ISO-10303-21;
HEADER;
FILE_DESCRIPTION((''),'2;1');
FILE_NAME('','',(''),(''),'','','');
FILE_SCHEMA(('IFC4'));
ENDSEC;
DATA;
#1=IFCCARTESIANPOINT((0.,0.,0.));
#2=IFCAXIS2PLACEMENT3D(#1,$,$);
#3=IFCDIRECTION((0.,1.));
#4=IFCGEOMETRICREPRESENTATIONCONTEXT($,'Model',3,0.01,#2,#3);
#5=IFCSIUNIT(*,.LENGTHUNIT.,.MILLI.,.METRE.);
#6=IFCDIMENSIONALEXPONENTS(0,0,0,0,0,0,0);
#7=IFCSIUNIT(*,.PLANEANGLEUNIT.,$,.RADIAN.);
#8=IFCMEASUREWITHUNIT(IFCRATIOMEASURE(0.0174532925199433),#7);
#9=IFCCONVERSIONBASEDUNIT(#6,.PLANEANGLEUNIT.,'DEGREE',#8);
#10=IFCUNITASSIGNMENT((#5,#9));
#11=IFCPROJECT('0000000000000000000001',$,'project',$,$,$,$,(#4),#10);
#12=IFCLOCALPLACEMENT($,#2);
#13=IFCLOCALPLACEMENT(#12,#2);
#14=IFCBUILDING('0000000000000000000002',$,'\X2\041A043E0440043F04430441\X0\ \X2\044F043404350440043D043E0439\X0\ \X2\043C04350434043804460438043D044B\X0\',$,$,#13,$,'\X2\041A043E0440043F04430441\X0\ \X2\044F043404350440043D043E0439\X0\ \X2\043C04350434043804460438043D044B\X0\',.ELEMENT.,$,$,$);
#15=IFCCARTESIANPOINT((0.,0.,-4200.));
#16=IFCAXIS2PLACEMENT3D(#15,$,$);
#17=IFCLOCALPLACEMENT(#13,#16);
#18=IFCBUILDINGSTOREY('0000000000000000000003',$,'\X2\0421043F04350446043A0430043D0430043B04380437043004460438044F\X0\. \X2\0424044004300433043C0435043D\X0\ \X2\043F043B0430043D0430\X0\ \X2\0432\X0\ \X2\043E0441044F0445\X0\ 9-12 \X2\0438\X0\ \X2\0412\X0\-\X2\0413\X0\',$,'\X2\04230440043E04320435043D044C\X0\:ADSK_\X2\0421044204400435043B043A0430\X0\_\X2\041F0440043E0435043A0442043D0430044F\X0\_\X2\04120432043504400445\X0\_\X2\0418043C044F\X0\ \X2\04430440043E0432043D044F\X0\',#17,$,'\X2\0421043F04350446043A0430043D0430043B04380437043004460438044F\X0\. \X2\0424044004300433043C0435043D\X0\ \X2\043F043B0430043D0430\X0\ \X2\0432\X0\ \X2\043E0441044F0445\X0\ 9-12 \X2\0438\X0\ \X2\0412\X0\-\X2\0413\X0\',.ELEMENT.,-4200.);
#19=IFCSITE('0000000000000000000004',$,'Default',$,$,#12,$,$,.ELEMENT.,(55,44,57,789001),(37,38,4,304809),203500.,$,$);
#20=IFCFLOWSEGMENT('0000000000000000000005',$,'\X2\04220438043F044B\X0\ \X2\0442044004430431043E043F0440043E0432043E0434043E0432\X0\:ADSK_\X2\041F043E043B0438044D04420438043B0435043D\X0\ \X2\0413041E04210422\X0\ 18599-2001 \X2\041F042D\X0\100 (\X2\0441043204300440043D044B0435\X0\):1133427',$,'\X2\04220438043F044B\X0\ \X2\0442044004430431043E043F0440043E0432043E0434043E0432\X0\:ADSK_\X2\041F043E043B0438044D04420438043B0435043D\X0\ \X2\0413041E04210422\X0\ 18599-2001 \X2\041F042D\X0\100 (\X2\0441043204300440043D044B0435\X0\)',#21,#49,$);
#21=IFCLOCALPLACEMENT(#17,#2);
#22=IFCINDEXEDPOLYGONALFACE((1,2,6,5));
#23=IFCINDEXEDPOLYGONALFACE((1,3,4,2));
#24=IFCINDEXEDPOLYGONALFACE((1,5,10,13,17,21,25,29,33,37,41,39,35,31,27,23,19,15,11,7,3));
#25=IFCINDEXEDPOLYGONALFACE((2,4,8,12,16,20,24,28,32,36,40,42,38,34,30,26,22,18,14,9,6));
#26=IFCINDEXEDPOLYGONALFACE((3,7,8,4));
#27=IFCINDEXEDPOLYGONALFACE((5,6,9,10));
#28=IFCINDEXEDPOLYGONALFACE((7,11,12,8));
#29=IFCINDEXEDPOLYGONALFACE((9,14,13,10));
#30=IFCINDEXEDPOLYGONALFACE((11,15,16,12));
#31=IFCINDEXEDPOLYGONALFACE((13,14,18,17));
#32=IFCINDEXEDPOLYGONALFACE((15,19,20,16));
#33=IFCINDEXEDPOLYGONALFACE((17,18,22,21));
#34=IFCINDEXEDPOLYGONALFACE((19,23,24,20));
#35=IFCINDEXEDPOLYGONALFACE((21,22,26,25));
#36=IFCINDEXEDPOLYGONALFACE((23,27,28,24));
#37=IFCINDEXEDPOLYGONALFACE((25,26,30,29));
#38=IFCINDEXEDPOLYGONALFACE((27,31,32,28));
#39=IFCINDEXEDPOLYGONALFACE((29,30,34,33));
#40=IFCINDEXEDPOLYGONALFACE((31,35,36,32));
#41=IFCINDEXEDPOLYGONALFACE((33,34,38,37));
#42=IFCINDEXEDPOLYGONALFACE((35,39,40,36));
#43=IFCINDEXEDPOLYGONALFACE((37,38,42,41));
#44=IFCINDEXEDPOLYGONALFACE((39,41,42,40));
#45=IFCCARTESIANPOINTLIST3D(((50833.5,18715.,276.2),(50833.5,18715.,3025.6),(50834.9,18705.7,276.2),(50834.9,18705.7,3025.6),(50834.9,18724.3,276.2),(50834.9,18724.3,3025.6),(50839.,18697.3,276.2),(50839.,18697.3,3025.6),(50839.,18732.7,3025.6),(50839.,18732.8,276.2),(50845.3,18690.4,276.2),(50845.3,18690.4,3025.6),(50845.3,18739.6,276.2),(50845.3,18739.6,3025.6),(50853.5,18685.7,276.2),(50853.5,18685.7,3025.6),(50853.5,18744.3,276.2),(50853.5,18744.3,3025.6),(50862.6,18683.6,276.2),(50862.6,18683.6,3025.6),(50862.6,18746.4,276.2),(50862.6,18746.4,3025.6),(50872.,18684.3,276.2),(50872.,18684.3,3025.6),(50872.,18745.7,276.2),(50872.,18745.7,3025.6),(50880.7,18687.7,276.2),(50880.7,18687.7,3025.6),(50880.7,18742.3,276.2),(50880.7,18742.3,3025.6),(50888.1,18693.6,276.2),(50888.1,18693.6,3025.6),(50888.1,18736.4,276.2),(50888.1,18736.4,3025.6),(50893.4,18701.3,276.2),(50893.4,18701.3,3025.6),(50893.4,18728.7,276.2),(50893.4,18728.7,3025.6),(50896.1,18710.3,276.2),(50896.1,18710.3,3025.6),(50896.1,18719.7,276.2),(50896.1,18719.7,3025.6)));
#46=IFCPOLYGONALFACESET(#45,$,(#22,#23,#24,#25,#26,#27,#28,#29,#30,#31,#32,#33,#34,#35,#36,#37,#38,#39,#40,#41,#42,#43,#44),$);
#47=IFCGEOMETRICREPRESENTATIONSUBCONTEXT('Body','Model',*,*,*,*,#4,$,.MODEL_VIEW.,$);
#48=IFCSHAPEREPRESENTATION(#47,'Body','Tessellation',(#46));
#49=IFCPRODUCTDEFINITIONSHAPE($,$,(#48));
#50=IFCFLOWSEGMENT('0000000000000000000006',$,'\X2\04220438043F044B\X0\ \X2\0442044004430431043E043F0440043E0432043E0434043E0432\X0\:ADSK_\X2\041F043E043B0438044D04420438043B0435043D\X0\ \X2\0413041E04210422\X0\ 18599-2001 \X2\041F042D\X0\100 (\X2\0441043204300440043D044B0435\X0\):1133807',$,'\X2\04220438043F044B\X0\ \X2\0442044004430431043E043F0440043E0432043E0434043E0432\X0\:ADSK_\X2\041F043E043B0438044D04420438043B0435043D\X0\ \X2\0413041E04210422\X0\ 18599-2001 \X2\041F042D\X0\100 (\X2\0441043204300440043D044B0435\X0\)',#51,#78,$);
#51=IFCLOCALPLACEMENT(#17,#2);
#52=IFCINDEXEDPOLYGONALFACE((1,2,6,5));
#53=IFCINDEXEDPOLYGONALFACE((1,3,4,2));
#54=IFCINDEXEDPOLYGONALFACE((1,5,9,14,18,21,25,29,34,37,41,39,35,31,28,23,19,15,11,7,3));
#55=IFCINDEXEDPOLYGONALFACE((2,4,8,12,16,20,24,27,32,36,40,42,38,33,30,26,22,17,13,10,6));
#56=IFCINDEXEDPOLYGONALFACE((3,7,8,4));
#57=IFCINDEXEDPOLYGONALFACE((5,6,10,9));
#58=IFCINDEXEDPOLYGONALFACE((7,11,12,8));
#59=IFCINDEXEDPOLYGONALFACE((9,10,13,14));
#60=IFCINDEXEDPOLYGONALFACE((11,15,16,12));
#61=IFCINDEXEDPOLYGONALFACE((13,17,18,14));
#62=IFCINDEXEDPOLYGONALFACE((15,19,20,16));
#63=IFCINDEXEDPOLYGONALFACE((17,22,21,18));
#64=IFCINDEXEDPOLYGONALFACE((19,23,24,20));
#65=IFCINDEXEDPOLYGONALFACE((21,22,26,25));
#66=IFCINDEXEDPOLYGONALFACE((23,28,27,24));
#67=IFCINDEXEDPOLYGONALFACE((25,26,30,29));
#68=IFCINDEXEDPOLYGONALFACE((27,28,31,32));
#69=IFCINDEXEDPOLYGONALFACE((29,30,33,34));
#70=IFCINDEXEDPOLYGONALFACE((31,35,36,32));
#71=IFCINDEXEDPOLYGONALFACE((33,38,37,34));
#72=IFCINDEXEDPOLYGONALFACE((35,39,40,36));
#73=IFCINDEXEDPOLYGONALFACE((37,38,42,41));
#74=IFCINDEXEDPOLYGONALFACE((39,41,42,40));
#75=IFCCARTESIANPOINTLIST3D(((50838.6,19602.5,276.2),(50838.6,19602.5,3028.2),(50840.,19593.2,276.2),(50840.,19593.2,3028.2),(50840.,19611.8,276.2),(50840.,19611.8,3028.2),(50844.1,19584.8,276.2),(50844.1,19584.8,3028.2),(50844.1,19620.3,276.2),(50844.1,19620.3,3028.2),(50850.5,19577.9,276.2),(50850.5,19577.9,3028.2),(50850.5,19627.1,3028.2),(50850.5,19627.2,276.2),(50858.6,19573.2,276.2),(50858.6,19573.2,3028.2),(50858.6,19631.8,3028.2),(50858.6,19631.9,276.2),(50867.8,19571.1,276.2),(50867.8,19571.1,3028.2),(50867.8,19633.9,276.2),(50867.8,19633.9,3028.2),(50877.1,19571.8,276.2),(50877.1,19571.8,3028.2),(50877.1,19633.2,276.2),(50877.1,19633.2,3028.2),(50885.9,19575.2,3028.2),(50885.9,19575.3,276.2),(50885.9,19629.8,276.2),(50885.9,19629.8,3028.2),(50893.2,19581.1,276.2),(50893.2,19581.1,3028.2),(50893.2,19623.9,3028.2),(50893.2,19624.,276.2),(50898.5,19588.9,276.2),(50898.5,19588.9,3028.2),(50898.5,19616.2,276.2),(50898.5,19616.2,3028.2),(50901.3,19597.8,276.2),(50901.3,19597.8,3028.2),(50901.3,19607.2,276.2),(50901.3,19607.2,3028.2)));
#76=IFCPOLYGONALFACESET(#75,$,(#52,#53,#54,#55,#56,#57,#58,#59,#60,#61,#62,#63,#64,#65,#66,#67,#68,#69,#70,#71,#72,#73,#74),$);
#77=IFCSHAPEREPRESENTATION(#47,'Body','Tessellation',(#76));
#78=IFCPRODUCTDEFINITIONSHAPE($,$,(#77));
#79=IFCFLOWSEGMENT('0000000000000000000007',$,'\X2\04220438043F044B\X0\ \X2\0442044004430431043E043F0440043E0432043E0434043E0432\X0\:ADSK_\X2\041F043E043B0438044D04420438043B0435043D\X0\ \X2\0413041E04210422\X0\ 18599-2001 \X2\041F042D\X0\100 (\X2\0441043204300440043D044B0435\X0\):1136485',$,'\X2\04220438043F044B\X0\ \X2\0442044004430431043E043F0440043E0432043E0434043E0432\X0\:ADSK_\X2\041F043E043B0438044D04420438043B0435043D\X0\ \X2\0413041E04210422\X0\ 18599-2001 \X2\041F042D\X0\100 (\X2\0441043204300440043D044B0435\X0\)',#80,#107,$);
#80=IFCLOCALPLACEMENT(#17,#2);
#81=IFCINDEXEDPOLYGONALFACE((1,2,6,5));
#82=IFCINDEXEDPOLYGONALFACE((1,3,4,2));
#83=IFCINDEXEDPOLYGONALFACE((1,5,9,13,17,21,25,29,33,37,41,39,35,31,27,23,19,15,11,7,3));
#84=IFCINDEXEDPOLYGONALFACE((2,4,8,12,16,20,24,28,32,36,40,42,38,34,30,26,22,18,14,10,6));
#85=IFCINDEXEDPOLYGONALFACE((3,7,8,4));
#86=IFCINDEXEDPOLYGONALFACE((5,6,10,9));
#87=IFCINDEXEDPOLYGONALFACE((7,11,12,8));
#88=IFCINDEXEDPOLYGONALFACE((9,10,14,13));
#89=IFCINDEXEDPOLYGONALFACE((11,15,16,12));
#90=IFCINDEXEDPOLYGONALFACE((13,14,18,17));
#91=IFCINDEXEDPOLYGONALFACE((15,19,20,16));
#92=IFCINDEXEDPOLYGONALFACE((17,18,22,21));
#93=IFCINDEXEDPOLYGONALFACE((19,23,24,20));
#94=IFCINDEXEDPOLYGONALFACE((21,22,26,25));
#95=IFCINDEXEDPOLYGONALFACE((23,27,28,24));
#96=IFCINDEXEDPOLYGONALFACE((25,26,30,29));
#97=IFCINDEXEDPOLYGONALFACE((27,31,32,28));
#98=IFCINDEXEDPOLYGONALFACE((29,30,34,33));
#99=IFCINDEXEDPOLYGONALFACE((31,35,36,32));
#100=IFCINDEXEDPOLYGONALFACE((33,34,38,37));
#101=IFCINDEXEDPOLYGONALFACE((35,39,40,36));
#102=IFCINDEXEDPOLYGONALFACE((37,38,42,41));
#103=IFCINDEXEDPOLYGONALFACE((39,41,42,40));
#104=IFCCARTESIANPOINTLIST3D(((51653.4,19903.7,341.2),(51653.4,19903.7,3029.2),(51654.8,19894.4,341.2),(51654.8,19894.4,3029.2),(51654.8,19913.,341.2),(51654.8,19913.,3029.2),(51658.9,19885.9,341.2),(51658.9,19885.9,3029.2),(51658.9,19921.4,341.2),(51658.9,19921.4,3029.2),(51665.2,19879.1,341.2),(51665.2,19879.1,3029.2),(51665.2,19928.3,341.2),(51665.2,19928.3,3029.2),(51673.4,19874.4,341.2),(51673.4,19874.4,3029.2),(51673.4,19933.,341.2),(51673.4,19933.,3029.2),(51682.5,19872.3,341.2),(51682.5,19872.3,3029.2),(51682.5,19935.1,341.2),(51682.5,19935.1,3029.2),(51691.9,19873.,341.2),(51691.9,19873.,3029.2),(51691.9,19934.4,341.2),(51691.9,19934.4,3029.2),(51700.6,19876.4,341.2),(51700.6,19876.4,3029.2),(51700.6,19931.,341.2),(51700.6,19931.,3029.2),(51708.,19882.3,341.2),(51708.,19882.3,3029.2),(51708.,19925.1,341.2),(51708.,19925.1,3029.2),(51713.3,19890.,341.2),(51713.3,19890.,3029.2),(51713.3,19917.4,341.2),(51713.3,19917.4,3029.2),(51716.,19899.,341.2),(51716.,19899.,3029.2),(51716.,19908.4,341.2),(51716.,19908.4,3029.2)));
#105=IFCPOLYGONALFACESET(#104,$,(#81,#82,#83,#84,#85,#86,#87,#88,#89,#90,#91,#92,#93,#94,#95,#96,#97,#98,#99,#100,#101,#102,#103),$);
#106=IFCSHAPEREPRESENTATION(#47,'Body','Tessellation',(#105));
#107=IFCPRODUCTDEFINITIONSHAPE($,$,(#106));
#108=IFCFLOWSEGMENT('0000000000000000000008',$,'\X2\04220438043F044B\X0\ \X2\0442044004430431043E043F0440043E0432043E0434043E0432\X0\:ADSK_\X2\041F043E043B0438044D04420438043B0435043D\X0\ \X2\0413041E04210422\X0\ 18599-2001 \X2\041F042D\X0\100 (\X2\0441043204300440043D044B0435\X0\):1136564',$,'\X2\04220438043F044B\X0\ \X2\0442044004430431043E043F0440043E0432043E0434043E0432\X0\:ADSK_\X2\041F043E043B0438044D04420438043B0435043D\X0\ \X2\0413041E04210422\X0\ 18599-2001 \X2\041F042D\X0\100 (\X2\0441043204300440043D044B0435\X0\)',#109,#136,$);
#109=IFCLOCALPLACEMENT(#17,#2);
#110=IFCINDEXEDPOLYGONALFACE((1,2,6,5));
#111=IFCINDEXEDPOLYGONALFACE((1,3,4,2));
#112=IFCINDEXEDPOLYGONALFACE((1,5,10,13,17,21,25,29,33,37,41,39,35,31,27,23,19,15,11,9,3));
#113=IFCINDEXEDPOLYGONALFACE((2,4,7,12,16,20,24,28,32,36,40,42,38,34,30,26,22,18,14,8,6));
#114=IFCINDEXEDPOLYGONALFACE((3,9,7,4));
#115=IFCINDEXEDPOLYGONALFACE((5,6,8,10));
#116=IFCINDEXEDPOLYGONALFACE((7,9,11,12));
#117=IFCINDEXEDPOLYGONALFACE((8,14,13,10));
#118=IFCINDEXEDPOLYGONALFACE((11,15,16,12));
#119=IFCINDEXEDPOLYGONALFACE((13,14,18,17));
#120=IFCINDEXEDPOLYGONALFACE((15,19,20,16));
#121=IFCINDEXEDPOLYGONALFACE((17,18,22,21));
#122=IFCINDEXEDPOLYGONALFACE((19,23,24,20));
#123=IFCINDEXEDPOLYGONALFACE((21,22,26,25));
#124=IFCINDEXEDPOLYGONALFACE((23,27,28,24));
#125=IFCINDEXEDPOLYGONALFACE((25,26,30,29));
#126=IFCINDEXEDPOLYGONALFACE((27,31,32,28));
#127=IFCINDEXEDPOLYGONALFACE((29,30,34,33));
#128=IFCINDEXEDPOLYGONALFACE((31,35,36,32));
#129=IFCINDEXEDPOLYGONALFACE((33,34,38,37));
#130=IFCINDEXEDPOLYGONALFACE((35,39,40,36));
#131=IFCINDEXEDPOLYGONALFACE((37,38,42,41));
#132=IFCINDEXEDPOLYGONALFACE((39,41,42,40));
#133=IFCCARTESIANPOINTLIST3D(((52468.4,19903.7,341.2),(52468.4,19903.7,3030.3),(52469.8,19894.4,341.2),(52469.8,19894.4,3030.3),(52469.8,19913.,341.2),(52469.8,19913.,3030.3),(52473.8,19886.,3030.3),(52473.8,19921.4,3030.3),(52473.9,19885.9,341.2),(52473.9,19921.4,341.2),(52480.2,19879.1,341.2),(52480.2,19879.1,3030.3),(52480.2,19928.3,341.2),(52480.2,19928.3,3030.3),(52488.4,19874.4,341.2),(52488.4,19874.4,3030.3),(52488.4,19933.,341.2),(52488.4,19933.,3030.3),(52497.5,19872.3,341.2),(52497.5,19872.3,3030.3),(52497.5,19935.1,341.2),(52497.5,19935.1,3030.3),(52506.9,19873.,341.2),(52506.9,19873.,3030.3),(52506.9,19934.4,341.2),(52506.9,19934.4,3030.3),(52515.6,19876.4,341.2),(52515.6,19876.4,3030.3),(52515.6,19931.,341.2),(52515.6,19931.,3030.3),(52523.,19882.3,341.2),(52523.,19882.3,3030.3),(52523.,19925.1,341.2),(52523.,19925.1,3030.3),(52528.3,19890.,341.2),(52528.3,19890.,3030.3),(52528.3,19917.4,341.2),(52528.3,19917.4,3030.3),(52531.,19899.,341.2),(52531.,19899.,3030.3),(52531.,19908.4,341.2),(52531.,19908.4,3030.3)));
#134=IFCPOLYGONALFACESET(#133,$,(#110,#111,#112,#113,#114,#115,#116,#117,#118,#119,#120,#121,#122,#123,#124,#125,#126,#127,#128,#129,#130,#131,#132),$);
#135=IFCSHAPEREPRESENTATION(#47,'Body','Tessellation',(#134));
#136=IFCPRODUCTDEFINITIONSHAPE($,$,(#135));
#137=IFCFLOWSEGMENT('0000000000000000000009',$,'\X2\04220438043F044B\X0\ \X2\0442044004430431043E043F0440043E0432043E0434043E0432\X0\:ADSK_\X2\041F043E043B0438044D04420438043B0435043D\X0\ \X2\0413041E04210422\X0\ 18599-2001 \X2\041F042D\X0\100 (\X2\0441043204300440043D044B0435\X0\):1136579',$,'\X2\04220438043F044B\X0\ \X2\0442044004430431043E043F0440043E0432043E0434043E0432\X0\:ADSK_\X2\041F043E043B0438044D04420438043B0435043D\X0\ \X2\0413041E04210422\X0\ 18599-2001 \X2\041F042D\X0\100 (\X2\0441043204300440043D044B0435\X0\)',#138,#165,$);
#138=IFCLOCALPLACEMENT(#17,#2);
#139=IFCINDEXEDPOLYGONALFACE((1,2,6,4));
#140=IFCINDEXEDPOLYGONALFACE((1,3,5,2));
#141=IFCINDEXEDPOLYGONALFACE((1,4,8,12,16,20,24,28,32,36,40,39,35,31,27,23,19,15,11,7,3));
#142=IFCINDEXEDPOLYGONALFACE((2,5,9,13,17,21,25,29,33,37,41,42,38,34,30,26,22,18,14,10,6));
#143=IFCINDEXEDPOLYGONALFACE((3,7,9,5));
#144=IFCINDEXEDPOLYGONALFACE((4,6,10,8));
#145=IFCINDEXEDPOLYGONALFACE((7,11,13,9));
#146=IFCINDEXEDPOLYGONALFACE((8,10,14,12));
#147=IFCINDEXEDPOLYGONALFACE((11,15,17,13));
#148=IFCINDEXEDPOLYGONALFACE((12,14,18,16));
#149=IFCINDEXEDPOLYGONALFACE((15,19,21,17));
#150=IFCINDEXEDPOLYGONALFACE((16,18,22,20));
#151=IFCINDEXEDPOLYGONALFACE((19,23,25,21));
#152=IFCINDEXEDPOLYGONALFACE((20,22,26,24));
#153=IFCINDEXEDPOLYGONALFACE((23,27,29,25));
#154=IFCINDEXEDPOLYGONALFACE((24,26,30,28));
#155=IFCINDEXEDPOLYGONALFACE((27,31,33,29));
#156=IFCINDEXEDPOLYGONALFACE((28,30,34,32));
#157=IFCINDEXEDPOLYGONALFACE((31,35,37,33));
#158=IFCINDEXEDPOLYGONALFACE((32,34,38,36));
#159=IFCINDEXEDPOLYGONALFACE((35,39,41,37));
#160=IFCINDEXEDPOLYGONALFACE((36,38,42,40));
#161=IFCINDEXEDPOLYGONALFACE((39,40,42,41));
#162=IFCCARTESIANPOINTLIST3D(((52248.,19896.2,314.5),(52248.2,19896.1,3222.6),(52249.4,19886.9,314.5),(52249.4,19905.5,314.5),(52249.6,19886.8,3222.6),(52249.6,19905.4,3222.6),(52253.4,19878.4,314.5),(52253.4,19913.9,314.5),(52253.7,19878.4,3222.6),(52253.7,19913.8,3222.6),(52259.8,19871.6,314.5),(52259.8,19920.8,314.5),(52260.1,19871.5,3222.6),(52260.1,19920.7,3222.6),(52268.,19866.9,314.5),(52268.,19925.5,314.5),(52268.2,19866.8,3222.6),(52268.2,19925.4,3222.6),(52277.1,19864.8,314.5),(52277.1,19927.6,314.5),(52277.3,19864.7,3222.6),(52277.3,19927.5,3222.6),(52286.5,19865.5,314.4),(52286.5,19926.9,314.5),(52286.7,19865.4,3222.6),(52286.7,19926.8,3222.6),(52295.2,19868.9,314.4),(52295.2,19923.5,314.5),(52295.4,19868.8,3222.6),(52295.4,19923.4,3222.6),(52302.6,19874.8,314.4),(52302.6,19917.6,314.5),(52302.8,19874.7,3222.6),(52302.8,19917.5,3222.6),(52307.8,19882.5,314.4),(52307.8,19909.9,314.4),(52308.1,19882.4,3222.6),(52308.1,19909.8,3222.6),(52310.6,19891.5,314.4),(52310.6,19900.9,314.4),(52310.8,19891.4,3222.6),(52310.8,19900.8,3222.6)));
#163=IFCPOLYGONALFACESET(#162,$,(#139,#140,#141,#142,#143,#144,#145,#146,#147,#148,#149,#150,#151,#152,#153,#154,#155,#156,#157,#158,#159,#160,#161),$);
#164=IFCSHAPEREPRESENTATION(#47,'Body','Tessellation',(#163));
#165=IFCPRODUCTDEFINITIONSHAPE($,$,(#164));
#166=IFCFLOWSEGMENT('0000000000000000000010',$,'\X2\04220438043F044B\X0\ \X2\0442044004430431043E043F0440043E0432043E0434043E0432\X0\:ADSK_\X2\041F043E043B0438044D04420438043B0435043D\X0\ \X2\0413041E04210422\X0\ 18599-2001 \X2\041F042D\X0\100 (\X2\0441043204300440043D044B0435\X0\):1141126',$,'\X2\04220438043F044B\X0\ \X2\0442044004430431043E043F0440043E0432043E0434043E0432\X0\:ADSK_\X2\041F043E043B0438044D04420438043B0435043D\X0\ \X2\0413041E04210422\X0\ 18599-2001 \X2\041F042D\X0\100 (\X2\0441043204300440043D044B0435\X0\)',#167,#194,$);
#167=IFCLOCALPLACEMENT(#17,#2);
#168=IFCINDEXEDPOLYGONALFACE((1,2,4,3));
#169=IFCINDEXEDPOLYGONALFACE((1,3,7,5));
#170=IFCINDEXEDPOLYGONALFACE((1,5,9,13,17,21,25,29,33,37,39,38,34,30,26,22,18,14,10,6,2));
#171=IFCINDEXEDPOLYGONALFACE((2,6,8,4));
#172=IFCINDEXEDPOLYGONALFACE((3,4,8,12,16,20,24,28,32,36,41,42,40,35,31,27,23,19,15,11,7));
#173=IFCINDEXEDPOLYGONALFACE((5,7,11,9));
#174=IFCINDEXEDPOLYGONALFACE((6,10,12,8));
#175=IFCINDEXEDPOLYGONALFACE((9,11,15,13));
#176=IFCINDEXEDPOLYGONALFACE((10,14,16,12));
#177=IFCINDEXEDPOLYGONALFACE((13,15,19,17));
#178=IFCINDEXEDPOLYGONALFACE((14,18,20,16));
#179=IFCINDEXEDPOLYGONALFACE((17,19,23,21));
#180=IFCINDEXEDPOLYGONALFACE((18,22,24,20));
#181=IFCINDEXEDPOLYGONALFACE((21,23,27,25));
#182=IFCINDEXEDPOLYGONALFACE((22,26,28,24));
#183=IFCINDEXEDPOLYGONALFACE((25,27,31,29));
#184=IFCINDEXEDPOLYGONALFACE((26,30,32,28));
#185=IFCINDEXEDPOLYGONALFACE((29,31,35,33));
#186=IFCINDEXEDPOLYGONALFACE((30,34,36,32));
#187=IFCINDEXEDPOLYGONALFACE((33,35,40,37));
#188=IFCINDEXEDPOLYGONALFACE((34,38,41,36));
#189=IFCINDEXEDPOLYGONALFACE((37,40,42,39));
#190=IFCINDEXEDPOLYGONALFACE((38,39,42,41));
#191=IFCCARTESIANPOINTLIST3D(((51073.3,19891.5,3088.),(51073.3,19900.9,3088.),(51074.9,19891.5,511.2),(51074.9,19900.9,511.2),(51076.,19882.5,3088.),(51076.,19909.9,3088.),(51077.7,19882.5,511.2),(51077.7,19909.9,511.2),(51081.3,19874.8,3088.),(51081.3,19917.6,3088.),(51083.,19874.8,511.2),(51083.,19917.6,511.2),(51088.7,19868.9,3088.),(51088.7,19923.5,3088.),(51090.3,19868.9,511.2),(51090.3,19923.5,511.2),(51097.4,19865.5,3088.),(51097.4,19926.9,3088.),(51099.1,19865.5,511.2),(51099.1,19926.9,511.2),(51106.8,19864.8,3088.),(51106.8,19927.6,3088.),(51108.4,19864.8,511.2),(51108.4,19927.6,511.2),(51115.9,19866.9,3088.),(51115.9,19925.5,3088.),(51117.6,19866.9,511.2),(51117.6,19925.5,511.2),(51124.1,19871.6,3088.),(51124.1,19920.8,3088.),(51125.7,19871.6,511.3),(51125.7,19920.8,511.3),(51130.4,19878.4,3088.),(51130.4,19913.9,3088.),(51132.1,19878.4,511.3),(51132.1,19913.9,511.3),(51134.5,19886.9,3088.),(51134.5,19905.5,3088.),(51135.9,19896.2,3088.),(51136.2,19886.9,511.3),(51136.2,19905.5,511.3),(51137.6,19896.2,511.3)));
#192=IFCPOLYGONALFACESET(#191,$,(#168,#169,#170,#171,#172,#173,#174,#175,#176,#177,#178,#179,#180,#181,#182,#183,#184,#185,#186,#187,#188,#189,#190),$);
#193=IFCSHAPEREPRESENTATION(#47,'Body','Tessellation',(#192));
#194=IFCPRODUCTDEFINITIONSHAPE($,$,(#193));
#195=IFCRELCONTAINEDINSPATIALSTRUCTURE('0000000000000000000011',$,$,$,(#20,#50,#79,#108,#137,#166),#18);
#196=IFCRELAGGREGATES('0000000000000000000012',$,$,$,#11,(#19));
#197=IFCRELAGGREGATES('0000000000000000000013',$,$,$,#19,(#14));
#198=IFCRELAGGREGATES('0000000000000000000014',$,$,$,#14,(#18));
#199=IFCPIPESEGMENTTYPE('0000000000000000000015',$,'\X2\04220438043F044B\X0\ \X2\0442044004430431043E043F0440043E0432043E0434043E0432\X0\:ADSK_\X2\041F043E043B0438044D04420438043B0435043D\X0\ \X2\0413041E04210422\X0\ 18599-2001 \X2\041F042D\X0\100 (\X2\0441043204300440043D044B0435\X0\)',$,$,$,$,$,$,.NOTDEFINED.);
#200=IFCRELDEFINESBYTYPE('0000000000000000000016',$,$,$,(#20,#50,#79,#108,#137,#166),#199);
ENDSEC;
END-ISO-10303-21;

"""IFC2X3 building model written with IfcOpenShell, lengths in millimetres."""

from ifc_helpers import new_model, entity, si_unit, converted_unit, direction, frame, frame_2d, origin, origin_2d_with_axis, place, context, subcontext, project, spatial, circle, extrude, type_object, element, save


model = new_model("IFC2X3")

# Units and contexts
model_context = context("Model", 3, precision=0.01, world=origin(), true_north=direction((0.0, 1.0)))
body_context = subcontext(model_context, "Body", "Model", "MODEL_VIEW")
ifc_project = project(units=[si_unit("LENGTHUNIT", "METRE", prefix="MILLI"), converted_unit("PLANEANGLEUNIT", "DEGREE", entity("IfcRatioMeasure", 0.0174532925199433), si_unit("PLANEANGLEUNIT", "RADIAN"), dimensions=[0, 0, 0, 0, 0, 0, 0])], contexts=[model_context])

# Site, building, storey
site_placement = place(None, frame((0.0, 0.0, 0.0)))
site = spatial("IfcSite", under=ifc_project, at=site_placement, Name="Default", CompositionType="ELEMENT", RefLatitude=(55, 44, 57, 789001), RefLongitude=(37, 38, 4, 304809), RefElevation=203500.0)
building_placement = place(site_placement, origin())
building = spatial("IfcBuilding", under=site, at=building_placement, Name="Корпус ядерной медицины", LongName="Корпус ядерной медицины", CompositionType="ELEMENT")
storey_placement = place(building_placement, frame((0.0, 0.0, -4200.0)))
storey = spatial("IfcBuildingStorey", under=building, at=storey_placement, Name="Спецканализация. Фрагмен плана в осях 9-12 и В-Г", ObjectType="Уровень:ADSK_Стрелка_Проектная_Вверх_Имя уровня", LongName="Спецканализация. Фрагмен плана в осях 9-12 и В-Г", CompositionType="ELEMENT", Elevation=-4200.0)

# Flow segments
pipe_segment_type = type_object("IfcPipeSegmentType", Name="Типы трубопроводов:ADSK_Полиэтилен ГОСТ 18599-2001 ПЭ100 (сварные)", PredefinedType="NOTDEFINED")
flow_segment_1_placement = place(storey_placement, frame((50831.9, 18681.9, 276.2)))
element("IfcFlowSegment", 1, at=flow_segment_1_placement, inside=storey, type_object=pipe_segment_type, Name="Типы трубопроводов:ADSK_Полиэтилен ГОСТ 18599-2001 ПЭ100 (сварные):1133427", ObjectType="Типы трубопроводов:ADSK_Полиэтилен ГОСТ 18599-2001 ПЭ100 (сварные)", context=body_context, shape_type="SweptSolid", body=[
    extrude(circle(Radius=31.5, at=origin_2d_with_axis()), frame((33.1, 33.1, 0.0), z_axis=(-0.000002, -0.000005, 1.0), x_axis=(-1.0, 0.0, -0.000002)), (0.0, 0.0, 1.0), 2749.4),
])
flow_segment_2_placement = place(storey_placement, frame((50837.0, 19569.4, 276.2)))
element("IfcFlowSegment", 2, at=flow_segment_2_placement, inside=storey, type_object=pipe_segment_type, Name="Типы трубопроводов:ADSK_Полиэтилен ГОСТ 18599-2001 ПЭ100 (сварные):1133807", ObjectType="Типы трубопроводов:ADSK_Полиэтилен ГОСТ 18599-2001 ПЭ100 (сварные)", context=body_context, shape_type="SweptSolid", body=[
    extrude(circle(Radius=31.5, at=origin_2d_with_axis()), frame((33.1, 33.1, 0.0), z_axis=(0.000005, -0.000004, 1.0), x_axis=(-1.0, 0.0, 0.000005)), (0.0, 0.0, 1.0), 2752.0),
])
flow_segment_3_placement = place(storey_placement, frame((51651.8, 19870.6, 341.2)))
element("IfcFlowSegment", 3, at=flow_segment_3_placement, inside=storey, type_object=pipe_segment_type, Name="Типы трубопроводов:ADSK_Полиэтилен ГОСТ 18599-2001 ПЭ100 (сварные):1136485", ObjectType="Типы трубопроводов:ADSK_Полиэтилен ГОСТ 18599-2001 ПЭ100 (сварные)", context=body_context, shape_type="SweptSolid", body=[
    extrude(circle(Radius=31.5, at=frame_2d((0.0, 0.0), x_axis=(1.0, 0.0))), frame((33.1, 33.1, 0.0), z_axis=(-0.000001, 0.0, 1.0), x_axis=(-1.0, 0.0, -0.000001)), (0.0, 0.0, 1.0), 2688.0),
])
flow_segment_4_placement = place(storey_placement, frame((52466.8, 19870.6, 341.2)))
element("IfcFlowSegment", 4, at=flow_segment_4_placement, inside=storey, type_object=pipe_segment_type, Name="Типы трубопроводов:ADSK_Полиэтилен ГОСТ 18599-2001 ПЭ100 (сварные):1136564", ObjectType="Типы трубопроводов:ADSK_Полиэтилен ГОСТ 18599-2001 ПЭ100 (сварные)", context=body_context, shape_type="SweptSolid", body=[
    extrude(circle(Radius=31.5, at=origin_2d_with_axis()), frame((33.1, 33.1, 0.0), z_axis=(-0.000004, 0.000005, 1.0), x_axis=(-1.0, 0.0, -0.000004)), (0.0, 0.0, 1.0), 2689.0),
])
flow_segment_5_placement = place(storey_placement, frame((52246.4, 19863.0, 314.4)))
element("IfcFlowSegment", 5, at=flow_segment_5_placement, inside=storey, type_object=pipe_segment_type, Name="Типы трубопроводов:ADSK_Полиэтилен ГОСТ 18599-2001 ПЭ100 (сварные):1136579", ObjectType="Типы трубопроводов:ADSK_Полиэтилен ГОСТ 18599-2001 ПЭ100 (сварные)", context=body_context, shape_type="SweptSolid", body=[
    extrude(circle(Radius=31.5, at=frame_2d((0.0, 0.0), x_axis=(1.0, 0.0))), frame((33.1, 33.2, 0.0), z_axis=(0.000078, -0.000028, 1.0), x_axis=(-1.0, 0.0, 0.000078)), (0.0, 0.0, 1.0), 2908.1),
])
flow_segment_6_placement = place(storey_placement, frame((51071.3, 19863.1, 511.2)))
element("IfcFlowSegment", 6, at=flow_segment_6_placement, inside=storey, type_object=pipe_segment_type, Name="Типы трубопроводов:ADSK_Полиэтилен ГОСТ 18599-2001 ПЭ100 (сварные):1141126", ObjectType="Типы трубопроводов:ADSK_Полиэтилен ГОСТ 18599-2001 ПЭ100 (сварные)", context=body_context, shape_type="SweptSolid", body=[
    extrude(circle(Radius=31.5, at=origin_2d_with_axis()), frame((34.8, 33.1, 0.0), z_axis=(-0.00065, 0.0, 1.0), x_axis=(1.0, 0.0, 0.00065)), (0.0, 0.0, 1.0), 2576.8),
])

save(model, "model.ifc")
